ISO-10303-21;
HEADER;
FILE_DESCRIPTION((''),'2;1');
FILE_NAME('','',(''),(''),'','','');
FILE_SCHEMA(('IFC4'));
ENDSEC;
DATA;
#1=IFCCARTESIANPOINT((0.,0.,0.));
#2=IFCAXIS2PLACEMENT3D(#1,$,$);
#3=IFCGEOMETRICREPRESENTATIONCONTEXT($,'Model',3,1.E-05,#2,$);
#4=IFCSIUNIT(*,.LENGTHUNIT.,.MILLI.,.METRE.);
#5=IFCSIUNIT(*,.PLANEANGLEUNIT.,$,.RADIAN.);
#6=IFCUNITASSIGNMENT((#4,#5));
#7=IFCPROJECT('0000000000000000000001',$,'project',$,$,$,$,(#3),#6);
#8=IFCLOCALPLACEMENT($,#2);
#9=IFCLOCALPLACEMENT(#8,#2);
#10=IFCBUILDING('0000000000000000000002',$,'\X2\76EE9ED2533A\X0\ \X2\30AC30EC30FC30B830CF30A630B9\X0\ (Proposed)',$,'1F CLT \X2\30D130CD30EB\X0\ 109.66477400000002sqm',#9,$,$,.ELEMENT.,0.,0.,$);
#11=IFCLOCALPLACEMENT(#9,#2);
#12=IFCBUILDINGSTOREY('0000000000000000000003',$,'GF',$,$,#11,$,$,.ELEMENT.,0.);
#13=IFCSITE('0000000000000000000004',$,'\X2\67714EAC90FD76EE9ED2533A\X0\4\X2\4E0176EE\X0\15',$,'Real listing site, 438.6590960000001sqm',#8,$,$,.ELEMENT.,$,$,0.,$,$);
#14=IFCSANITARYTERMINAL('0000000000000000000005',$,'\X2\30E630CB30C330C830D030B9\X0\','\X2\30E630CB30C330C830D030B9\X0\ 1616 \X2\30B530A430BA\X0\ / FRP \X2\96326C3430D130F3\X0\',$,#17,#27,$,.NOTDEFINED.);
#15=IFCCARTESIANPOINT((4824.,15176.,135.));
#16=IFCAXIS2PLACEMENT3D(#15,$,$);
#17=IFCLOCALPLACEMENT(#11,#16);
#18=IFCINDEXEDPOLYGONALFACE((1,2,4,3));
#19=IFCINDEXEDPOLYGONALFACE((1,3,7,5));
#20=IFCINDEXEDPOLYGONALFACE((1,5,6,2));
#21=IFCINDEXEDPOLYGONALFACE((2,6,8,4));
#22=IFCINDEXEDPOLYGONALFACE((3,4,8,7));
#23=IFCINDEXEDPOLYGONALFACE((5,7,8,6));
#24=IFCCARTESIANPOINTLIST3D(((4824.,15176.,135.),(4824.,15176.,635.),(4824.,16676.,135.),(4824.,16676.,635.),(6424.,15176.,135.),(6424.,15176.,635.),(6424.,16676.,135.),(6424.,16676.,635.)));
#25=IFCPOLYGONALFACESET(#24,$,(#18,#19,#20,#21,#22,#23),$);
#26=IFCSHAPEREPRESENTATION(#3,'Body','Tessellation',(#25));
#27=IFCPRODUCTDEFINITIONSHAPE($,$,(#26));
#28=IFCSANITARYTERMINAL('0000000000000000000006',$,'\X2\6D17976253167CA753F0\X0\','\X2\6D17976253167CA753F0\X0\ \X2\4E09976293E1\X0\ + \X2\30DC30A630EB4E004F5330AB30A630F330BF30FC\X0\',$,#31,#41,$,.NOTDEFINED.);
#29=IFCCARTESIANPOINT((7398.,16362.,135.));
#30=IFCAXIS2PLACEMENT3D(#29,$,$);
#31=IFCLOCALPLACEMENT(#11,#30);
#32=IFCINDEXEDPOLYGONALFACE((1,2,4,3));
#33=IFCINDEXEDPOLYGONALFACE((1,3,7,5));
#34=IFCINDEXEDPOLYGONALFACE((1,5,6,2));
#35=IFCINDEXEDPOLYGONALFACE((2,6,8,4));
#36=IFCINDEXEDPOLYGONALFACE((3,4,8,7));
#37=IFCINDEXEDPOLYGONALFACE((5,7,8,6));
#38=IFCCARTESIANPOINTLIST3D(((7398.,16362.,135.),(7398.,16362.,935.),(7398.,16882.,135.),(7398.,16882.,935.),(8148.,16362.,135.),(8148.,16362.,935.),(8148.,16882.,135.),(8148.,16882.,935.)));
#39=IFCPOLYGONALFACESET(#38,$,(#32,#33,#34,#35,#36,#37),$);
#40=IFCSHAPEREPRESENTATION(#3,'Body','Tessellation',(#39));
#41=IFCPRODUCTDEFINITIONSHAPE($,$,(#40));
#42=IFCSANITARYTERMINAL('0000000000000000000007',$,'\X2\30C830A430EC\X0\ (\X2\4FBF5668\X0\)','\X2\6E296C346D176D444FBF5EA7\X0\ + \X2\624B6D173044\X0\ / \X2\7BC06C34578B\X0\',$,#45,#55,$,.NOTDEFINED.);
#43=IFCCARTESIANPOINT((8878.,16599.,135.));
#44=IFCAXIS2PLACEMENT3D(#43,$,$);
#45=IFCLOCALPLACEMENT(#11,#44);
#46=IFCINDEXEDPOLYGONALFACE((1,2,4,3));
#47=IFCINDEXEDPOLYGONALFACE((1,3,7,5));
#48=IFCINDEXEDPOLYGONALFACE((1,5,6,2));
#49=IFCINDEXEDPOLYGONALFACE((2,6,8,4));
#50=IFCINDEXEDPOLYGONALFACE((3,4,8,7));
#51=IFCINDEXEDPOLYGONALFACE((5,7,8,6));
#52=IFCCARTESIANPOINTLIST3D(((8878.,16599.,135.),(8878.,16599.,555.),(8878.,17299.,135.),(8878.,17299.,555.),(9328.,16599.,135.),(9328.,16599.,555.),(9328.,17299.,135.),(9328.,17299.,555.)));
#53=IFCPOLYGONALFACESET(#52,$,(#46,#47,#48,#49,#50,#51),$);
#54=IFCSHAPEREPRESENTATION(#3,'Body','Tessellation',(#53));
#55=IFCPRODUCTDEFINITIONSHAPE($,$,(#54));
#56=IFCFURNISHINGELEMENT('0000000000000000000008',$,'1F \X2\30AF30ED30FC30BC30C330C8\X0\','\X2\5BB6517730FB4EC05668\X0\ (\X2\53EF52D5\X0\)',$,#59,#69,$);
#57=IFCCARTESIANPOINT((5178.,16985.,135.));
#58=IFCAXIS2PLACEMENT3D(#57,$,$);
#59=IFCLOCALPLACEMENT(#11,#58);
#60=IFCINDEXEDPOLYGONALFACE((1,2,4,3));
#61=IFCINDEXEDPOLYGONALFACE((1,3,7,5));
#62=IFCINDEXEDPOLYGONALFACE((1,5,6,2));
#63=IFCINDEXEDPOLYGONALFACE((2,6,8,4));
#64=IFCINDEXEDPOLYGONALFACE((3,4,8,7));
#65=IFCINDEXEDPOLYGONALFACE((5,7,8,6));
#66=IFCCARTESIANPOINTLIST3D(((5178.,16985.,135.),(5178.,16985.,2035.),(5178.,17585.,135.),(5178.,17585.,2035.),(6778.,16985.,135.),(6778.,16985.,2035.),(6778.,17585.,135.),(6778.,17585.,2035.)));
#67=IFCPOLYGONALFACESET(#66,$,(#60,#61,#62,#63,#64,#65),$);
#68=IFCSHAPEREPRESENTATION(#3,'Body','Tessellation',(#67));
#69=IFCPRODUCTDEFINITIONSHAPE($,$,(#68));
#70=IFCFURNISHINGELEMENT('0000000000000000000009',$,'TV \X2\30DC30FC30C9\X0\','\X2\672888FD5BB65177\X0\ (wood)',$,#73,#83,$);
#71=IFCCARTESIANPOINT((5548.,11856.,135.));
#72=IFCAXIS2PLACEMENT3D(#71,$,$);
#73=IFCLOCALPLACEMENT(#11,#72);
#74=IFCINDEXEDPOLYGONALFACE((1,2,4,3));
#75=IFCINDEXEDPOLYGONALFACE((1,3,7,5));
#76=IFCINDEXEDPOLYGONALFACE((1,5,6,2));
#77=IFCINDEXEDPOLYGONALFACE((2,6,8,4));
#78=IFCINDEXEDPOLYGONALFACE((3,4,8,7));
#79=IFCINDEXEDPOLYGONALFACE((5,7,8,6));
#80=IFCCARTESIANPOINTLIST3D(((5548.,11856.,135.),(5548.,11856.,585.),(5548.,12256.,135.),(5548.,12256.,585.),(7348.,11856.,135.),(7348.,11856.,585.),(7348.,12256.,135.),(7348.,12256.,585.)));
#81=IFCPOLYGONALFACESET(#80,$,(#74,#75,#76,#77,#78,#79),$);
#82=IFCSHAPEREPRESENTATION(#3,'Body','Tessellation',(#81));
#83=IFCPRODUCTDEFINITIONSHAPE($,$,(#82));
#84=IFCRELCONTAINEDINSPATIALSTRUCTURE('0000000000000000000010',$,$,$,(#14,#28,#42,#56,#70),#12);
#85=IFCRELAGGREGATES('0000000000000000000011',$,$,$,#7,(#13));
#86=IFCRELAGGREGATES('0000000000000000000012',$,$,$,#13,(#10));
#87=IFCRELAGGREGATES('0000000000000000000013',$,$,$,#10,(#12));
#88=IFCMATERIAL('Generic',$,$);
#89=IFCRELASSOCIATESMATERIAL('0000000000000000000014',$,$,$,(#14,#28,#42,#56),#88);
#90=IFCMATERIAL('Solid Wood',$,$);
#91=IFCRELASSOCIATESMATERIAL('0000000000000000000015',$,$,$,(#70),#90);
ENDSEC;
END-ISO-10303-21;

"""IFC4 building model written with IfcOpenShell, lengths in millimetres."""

from ifc_helpers import new_model, si_unit, frame, frame_2d, origin, place, context, project, spatial, rectangle, extrude, material, element, save


model = new_model("IFC4")

# Units and contexts
model_context = context("Model", 3, precision=1e-05, world=origin())
ifc_project = project(units=[si_unit("LENGTHUNIT", "METRE", prefix="MILLI"), si_unit("PLANEANGLEUNIT", "RADIAN")], contexts=[model_context])

# Site, building, storey
site_placement = place(None, origin())
site = spatial("IfcSite", under=ifc_project, at=site_placement, Name="東京都目黒区4丁目15", ObjectType="Real listing site, 438.6590960000001sqm", CompositionType="ELEMENT", RefElevation=0.0)
building_placement = place(site_placement, origin())
building = spatial("IfcBuilding", under=site, at=building_placement, Name="目黒区 ガレージハウス (Proposed)", ObjectType="1F CLT パネル 109.66477400000002sqm", CompositionType="ELEMENT", ElevationOfRefHeight=0.0, ElevationOfTerrain=0.0)
storey_placement = place(building_placement, origin())
storey = spatial("IfcBuildingStorey", under=building, at=storey_placement, Name="GF", CompositionType="ELEMENT", Elevation=0.0)

# Shared definitions
ifc_material_1 = material(Name="Solid Wood")

# Shared definitions
ifc_material_2 = material(Name="Generic")

# Sanitary terminals
sanitary_terminal_1_placement = place(storey_placement, frame((4824.0, 15176.0, 135.0)))
element("IfcSanitaryTerminal", 1, at=sanitary_terminal_1_placement, inside=storey, material=ifc_material_2, Name="ユニットバス", Description="ユニットバス 1616 サイズ / FRP 防水パン", PredefinedType="NOTDEFINED", context=model_context, shape_type="SweptSolid", body=[
    extrude(rectangle(XDim=1600.0, YDim=1500.0, at=frame_2d((800.0, 750.0))), frame((4824.0, 15176.0, 135.0)), (0.0, 0.0, 1.0), 500.0),
])
sanitary_terminal_2_placement = place(storey_placement, frame((7398.0, 16362.0, 135.0)))
element("IfcSanitaryTerminal", 2, at=sanitary_terminal_2_placement, inside=storey, material=ifc_material_2, Name="洗面化粧台", Description="洗面化粧台 三面鏡 + ボウル一体カウンター", PredefinedType="NOTDEFINED", context=model_context, shape_type="SweptSolid", body=[
    extrude(rectangle(XDim=750.0, YDim=520.0, at=frame_2d((375.0, 260.0))), frame((7398.0, 16362.0, 135.0)), (0.0, 0.0, 1.0), 800.0),
])
sanitary_terminal_3_placement = place(storey_placement, frame((8878.0, 16599.0, 135.0)))
element("IfcSanitaryTerminal", 3, at=sanitary_terminal_3_placement, inside=storey, material=ifc_material_2, Name="トイレ (便器)", Description="温水洗浄便座 + 手洗い / 節水型", PredefinedType="NOTDEFINED", context=model_context, shape_type="SweptSolid", body=[
    extrude(rectangle(XDim=450.0, YDim=700.0, at=frame_2d((225.0, 350.0))), frame((8878.0, 16599.0, 135.0)), (0.0, 0.0, 1.0), 420.0),
])

# Furnishing elements
furnishing_1_placement = place(storey_placement, frame((5178.0, 16985.0, 135.0)))
element("IfcFurnishingElement", 4, at=furnishing_1_placement, inside=storey, material=ifc_material_2, Name="1F クローゼット", Description="家具・什器 (可動)", context=model_context, shape_type="SweptSolid", body=[
    extrude(rectangle(XDim=1600.0, YDim=600.0, at=frame_2d((800.0, 300.0))), frame((5178.0, 16985.0, 135.0)), (0.0, 0.0, 1.0), 1900.0),
])
furnishing_2_placement = place(storey_placement, frame((5548.0, 11856.0, 135.0)))
element("IfcFurnishingElement", 5, at=furnishing_2_placement, inside=storey, material=ifc_material_1, Name="TV ボード", Description="木製家具 (wood)", context=model_context, shape_type="SweptSolid", body=[
    extrude(rectangle(XDim=1800.0, YDim=400.0, at=frame_2d((900.0, 200.0))), frame((5548.0, 11856.0, 135.0)), (0.0, 0.0, 1.0), 450.0),
])

save(model, "model.ifc")
